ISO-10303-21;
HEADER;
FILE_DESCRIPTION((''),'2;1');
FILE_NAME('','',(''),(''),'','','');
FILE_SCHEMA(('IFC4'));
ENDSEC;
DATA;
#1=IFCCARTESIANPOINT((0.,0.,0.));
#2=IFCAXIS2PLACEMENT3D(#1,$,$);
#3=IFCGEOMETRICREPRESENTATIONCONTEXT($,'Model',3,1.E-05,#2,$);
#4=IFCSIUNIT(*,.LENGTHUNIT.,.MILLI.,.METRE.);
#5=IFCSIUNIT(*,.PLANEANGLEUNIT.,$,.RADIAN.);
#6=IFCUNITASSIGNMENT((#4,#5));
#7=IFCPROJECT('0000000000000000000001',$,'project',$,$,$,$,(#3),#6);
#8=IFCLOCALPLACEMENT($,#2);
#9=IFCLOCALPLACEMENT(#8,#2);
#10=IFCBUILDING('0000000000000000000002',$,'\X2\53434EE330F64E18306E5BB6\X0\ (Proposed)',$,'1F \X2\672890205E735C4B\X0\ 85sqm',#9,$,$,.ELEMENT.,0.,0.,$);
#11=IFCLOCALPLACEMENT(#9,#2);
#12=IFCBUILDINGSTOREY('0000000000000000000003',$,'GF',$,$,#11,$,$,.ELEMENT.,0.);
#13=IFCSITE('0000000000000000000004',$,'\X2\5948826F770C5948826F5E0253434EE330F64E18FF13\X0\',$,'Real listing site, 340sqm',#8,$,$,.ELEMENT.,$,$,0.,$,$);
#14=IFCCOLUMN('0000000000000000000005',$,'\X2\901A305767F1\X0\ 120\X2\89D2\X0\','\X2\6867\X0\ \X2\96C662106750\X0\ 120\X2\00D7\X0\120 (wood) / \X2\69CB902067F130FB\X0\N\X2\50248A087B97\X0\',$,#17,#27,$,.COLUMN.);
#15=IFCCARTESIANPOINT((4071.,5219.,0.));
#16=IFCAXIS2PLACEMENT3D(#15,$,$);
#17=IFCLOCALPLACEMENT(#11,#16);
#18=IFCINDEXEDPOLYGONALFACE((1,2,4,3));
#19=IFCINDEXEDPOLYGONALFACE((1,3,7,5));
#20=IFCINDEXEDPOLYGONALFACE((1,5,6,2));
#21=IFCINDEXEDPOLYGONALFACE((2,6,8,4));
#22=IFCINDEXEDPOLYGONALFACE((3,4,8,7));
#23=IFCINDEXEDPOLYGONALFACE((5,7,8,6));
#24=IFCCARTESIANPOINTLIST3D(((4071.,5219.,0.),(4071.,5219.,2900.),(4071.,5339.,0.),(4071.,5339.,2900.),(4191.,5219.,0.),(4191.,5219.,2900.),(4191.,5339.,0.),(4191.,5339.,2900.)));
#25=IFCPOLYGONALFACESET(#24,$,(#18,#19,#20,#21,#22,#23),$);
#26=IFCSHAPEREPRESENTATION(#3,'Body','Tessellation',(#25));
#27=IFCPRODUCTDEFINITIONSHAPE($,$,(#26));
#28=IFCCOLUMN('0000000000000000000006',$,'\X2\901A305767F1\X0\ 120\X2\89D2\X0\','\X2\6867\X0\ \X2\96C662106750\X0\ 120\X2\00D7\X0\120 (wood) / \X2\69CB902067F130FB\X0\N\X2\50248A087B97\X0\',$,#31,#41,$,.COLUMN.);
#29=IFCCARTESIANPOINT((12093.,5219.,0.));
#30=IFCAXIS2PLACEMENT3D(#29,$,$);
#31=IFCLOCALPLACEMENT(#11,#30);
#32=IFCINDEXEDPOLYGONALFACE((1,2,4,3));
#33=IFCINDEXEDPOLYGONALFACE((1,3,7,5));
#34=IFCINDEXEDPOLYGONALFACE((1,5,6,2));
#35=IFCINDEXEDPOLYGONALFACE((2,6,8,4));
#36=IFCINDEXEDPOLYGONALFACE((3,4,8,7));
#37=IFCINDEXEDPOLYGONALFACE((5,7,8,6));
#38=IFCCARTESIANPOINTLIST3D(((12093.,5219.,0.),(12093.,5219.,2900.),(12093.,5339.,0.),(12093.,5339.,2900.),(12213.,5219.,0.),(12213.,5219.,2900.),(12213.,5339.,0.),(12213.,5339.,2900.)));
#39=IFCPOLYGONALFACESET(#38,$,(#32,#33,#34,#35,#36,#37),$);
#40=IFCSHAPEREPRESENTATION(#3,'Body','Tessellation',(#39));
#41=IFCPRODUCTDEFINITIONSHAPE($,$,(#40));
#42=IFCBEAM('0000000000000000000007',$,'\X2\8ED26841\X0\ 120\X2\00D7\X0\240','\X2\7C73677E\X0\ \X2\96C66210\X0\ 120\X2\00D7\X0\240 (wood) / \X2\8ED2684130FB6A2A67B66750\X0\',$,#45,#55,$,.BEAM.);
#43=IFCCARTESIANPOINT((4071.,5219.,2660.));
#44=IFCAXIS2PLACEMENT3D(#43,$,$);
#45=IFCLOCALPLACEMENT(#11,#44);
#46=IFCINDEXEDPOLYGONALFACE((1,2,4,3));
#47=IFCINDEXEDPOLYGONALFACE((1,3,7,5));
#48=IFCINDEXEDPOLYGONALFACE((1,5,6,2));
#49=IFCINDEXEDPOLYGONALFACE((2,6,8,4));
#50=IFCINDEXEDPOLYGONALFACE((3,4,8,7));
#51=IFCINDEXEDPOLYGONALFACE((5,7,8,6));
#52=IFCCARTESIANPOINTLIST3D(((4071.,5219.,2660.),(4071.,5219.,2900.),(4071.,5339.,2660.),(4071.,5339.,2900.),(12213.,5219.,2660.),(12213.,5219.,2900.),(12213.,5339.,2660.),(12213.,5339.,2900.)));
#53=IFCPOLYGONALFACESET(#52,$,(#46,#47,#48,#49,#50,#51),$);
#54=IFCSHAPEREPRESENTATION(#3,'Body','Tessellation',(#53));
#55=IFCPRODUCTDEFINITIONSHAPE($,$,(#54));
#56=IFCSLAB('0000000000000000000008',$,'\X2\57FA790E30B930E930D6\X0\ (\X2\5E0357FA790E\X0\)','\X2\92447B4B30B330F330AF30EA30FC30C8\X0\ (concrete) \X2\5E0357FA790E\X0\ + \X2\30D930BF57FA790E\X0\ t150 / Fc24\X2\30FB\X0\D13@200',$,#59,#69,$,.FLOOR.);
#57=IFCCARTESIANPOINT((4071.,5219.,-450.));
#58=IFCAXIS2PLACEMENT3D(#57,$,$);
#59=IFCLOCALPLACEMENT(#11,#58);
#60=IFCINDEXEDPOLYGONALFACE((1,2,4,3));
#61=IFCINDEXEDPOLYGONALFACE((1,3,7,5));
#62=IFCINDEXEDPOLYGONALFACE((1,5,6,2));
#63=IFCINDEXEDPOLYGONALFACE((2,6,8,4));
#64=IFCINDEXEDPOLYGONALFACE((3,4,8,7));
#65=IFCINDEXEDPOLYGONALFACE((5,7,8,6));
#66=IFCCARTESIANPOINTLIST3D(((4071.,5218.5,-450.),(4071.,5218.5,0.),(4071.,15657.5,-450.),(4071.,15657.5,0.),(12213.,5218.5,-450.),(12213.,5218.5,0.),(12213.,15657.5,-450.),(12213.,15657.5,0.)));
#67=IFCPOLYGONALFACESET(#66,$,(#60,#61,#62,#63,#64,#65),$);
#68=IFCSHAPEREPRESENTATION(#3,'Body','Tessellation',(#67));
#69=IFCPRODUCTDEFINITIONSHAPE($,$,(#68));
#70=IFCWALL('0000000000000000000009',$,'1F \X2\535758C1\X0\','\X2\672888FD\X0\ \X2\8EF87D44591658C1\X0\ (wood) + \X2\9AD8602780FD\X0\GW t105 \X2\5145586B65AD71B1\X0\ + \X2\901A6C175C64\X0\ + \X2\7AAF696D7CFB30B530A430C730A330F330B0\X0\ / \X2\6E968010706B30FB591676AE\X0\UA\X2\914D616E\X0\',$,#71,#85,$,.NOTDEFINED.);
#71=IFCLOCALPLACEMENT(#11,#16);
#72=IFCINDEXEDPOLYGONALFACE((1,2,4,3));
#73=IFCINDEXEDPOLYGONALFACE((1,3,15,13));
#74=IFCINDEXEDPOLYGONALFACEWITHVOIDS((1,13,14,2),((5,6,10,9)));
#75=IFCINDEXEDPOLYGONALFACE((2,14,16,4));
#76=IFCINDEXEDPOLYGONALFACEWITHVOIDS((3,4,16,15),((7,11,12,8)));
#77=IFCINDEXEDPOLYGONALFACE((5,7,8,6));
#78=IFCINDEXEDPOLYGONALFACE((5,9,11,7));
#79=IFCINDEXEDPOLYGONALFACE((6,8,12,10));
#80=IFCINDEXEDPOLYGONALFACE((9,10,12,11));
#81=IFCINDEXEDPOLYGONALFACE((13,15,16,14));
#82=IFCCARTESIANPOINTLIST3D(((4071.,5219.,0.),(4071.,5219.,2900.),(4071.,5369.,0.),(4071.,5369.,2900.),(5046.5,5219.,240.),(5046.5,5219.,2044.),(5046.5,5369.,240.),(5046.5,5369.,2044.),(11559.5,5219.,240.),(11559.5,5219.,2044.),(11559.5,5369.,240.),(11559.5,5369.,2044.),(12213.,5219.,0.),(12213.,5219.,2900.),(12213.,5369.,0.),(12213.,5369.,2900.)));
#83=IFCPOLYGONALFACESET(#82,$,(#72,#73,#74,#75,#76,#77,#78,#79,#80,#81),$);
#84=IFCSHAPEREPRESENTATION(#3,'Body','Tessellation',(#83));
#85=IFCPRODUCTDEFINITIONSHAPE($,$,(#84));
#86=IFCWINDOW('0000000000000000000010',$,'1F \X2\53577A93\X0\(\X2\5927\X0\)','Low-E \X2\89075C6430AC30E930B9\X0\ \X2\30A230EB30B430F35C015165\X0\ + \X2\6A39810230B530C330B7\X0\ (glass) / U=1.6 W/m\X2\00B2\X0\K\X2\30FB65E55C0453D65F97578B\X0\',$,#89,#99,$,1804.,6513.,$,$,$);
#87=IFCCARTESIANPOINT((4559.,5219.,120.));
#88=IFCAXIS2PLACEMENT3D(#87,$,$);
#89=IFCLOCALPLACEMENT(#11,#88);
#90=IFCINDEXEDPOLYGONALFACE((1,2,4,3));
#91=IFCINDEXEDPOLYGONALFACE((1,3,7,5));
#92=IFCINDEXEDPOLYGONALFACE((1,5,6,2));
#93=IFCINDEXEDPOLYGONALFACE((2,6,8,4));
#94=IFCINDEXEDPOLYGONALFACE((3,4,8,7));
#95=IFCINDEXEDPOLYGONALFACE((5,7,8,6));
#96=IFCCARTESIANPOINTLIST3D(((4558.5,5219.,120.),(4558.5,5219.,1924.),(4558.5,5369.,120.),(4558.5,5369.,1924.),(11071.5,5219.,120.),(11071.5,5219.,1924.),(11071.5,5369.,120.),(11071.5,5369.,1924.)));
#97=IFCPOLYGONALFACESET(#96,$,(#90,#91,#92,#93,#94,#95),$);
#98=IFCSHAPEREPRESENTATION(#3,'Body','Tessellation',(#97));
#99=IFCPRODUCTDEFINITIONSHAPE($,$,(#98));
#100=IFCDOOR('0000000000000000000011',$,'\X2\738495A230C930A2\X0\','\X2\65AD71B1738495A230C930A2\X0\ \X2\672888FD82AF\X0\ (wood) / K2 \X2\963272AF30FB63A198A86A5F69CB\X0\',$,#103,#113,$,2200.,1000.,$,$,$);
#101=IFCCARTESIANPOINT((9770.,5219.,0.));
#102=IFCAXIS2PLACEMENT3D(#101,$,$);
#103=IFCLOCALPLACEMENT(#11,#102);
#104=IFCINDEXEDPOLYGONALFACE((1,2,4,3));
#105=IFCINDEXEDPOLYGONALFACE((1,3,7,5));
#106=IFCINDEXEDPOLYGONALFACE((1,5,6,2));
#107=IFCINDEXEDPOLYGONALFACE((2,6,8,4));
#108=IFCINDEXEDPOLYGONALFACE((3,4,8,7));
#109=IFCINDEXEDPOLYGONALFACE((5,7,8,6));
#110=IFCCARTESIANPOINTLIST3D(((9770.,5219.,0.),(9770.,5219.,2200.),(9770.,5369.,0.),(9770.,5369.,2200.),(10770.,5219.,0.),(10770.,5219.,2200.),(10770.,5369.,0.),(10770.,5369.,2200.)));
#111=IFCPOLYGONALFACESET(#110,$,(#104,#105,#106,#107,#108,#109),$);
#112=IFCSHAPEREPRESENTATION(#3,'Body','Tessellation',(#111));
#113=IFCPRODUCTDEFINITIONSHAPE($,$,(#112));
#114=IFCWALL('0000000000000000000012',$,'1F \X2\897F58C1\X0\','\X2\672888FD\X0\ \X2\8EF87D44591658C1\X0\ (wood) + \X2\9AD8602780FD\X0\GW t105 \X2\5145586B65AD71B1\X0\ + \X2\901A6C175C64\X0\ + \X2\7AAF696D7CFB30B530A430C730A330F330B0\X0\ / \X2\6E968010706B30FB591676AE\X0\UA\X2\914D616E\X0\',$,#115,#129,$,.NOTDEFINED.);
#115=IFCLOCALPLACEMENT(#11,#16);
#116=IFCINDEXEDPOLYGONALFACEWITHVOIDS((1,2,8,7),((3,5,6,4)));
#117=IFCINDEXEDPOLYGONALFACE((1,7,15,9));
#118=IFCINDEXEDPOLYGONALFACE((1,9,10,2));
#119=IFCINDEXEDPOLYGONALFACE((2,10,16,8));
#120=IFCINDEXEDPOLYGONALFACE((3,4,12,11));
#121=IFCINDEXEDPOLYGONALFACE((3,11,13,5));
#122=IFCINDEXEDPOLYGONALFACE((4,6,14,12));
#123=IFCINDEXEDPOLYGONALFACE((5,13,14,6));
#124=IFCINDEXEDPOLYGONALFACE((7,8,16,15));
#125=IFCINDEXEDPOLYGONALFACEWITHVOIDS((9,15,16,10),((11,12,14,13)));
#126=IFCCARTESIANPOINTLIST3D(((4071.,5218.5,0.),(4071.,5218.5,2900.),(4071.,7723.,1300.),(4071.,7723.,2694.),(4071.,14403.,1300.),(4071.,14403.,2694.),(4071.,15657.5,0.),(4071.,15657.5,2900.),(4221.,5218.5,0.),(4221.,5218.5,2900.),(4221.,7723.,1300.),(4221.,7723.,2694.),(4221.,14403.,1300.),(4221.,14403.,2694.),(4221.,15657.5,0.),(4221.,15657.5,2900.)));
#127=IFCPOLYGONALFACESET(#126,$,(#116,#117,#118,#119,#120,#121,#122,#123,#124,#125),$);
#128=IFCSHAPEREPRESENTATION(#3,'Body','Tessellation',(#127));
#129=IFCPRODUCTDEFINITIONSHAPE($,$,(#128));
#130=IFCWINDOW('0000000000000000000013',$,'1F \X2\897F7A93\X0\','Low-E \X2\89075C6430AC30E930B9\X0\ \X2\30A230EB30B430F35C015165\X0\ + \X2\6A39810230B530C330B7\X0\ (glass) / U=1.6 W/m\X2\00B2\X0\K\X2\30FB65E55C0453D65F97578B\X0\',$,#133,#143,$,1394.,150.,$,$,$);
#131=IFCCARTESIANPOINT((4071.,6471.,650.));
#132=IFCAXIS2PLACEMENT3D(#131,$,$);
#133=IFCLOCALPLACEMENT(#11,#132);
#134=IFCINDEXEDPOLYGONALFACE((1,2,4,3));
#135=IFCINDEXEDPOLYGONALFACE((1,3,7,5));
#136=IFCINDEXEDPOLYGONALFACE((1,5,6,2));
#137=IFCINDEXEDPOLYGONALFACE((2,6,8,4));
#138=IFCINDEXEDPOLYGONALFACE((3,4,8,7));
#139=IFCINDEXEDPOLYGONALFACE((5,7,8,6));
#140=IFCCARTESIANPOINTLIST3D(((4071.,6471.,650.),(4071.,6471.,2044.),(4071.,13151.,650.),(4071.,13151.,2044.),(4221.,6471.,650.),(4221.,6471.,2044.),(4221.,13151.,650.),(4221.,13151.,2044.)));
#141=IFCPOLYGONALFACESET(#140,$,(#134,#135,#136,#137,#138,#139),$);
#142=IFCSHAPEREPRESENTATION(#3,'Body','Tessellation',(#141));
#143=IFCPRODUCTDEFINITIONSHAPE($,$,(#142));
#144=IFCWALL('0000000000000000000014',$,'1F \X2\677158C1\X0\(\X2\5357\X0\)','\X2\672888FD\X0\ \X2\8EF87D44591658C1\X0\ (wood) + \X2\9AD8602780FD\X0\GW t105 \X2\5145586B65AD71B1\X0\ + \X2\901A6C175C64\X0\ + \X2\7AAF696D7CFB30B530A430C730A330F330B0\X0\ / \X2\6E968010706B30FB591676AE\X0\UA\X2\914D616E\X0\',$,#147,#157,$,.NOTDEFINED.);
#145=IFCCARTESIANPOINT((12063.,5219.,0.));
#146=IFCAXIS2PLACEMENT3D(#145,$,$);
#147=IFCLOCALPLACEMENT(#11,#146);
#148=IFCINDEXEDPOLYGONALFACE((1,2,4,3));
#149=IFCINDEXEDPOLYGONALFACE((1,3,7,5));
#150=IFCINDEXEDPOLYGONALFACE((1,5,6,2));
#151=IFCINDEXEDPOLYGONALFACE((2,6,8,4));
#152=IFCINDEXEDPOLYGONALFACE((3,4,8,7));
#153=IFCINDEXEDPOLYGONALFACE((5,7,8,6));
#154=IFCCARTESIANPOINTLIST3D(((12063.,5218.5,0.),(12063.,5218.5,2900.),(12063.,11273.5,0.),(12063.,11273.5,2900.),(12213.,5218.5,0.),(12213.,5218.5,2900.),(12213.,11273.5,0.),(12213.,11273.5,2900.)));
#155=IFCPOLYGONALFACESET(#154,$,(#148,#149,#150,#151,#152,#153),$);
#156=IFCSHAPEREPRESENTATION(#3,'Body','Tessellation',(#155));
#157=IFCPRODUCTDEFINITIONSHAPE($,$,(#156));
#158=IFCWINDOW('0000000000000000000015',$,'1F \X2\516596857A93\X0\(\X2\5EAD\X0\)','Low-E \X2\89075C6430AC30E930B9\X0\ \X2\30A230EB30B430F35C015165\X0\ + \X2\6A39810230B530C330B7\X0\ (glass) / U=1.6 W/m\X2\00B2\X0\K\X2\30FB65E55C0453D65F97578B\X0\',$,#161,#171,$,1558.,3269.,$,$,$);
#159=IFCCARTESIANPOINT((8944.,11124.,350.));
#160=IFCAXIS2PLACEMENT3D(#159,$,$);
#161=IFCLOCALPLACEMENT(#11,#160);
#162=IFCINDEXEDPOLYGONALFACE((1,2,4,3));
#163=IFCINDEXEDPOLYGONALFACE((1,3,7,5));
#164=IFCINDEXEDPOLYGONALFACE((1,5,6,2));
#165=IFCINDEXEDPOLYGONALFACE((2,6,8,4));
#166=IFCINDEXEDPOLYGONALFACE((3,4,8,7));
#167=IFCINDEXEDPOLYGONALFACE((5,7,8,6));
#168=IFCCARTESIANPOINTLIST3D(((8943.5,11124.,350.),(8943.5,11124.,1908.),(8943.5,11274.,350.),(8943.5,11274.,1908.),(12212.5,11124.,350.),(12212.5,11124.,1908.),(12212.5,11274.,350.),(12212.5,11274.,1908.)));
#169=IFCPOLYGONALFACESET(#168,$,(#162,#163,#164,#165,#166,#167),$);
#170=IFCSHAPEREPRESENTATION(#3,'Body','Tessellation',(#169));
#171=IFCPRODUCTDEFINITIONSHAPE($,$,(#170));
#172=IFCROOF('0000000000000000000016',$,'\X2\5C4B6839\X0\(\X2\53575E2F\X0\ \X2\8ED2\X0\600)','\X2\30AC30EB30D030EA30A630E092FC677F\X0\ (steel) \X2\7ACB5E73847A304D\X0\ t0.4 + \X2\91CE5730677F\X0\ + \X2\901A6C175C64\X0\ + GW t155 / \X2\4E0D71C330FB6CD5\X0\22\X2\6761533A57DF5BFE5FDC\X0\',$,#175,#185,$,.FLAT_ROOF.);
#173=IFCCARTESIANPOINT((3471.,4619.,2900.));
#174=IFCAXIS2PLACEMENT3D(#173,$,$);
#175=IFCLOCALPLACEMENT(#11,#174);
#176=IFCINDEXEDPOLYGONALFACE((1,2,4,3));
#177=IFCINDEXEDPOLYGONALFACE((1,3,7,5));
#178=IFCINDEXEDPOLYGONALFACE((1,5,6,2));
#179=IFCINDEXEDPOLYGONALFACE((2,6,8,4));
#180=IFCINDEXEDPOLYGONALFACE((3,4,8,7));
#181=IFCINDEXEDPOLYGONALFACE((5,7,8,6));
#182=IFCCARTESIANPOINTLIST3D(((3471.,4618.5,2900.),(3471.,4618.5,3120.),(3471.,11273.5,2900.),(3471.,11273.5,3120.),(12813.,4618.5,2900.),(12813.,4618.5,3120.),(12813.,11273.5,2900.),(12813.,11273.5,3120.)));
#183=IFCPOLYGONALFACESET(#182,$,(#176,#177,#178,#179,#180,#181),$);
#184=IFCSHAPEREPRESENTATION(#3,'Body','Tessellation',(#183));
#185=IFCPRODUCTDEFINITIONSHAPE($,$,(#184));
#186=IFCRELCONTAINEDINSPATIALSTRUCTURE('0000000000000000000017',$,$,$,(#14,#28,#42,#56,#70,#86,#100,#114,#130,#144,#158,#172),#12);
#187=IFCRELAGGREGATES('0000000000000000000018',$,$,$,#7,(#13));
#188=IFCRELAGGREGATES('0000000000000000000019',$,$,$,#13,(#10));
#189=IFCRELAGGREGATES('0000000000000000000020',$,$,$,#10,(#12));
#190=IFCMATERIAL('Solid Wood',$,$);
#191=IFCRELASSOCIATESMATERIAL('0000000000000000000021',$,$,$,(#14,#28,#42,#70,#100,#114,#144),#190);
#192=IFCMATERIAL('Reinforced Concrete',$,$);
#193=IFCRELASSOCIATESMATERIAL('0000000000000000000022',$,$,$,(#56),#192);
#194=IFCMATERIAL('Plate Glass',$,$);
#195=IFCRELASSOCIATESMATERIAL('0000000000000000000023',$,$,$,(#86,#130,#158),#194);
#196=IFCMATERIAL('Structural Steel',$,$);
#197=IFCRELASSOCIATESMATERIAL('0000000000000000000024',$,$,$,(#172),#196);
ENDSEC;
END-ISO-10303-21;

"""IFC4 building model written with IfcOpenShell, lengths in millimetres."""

from ifc_helpers import new_model, si_unit, frame, frame_2d, origin, place, context, project, spatial, rectangle, extrude, material, element, fill, save


model = new_model("IFC4")

# Units and contexts
model_context = context("Model", 3, precision=1e-05, world=origin())
ifc_project = project(units=[si_unit("LENGTHUNIT", "METRE", prefix="MILLI"), si_unit("PLANEANGLEUNIT", "RADIAN")], contexts=[model_context])

# Site, building, storey
site_placement = place(None, origin())
site = spatial("IfcSite", under=ifc_project, at=site_placement, Name="奈良県奈良市千代ヶ丘３", ObjectType="Real listing site, 340sqm", CompositionType="ELEMENT", RefElevation=0.0)
building_placement = place(site_placement, origin())
building = spatial("IfcBuilding", under=site, at=building_placement, Name="千代ヶ丘の家 (Proposed)", ObjectType="1F 木造平屋 85sqm", CompositionType="ELEMENT", ElevationOfRefHeight=0.0, ElevationOfTerrain=0.0)
storey_placement = place(building_placement, origin())
storey = spatial("IfcBuildingStorey", under=building, at=storey_placement, Name="GF", CompositionType="ELEMENT", Elevation=0.0)

# Columns
ifc_material_1 = material(Name="Solid Wood")
column_1_placement = place(storey_placement, frame((4071.0, 5219.0, 0.0)))
element("IfcColumn", 1, at=column_1_placement, inside=storey, material=ifc_material_1, Name="通し柱 120角", Description="桧 集成材 120×120 (wood) / 構造柱・N値計算", PredefinedType="COLUMN", context=model_context, shape_type="SweptSolid", body=[
    extrude(rectangle(XDim=120.0, YDim=120.0, at=frame_2d((60.0, 60.0))), frame((4071.0, 5219.0, 0.0)), (0.0, 0.0, 1.0), 2900.0),
])
column_2_placement = place(storey_placement, frame((12093.0, 5219.0, 0.0)))
element("IfcColumn", 2, at=column_2_placement, inside=storey, material=ifc_material_1, Name="通し柱 120角", Description="桧 集成材 120×120 (wood) / 構造柱・N値計算", PredefinedType="COLUMN", context=model_context, shape_type="SweptSolid", body=[
    extrude(rectangle(XDim=120.0, YDim=120.0, at=frame_2d((60.0, 60.0))), frame((12093.0, 5219.0, 0.0)), (0.0, 0.0, 1.0), 2900.0),
])

# Beam
beam_1_placement = place(storey_placement, frame((4071.0, 5219.0, 2660.0)))
element("IfcBeam", 3, at=beam_1_placement, inside=storey, material=ifc_material_1, Name="軒桁 120×240", Description="米松 集成 120×240 (wood) / 軒桁・横架材", PredefinedType="BEAM", context=model_context, shape_type="SweptSolid", body=[
    extrude(rectangle(XDim=8142.0, YDim=120.0, at=frame_2d((4071.0, 60.0))), frame((4071.0, 5219.0, 2660.0)), (0.0, 0.0, 1.0), 240.0),
])

# Slab
ifc_material_2 = material(Name="Reinforced Concrete")
slab_1_placement = place(storey_placement, frame((4071.0, 5219.0, -450.0)))
element("IfcSlab", 4, at=slab_1_placement, inside=storey, material=ifc_material_2, Name="基礎スラブ (布基礎)", Description="鉄筋コンクリート (concrete) 布基礎 + ベタ基礎 t150 / Fc24・D13@200", PredefinedType="FLOOR", context=model_context, shape_type="SweptSolid", body=[
    extrude(rectangle(XDim=8142.0, YDim=10439.0, at=frame_2d((4071.0, 5219.0))), frame((4071.0, 5219.0, -450.0)), (0.0, 0.0, 1.0), 450.0),
])

# Wall, openings, window, door
wall_1_placement = place(storey_placement, frame((4071.0, 5219.0, 0.0)))
wall_1 = element("IfcWall", 5, at=wall_1_placement, inside=storey, material=ifc_material_1, Name="1F 南壁", Description="木製 軸組外壁 (wood) + 高性能GW t105 充填断熱 + 通気層 + 窯業系サイディング / 準耐火・外皮UA配慮", PredefinedType="NOTDEFINED", context=model_context, shape_type="SweptSolid", body=[
    extrude(rectangle(XDim=8142.0, YDim=150.0, at=frame_2d((4071.0, 75.0))), frame((4071.0, 5219.0, 0.0)), (0.0, 0.0, 1.0), 2900.0),
])
opening_1_placement = place(storey_placement, frame((4559.0, 5219.0, 120.0)))
opening_1 = element("IfcOpeningElement", 6, at=opening_1_placement, cuts=wall_1, PredefinedType="NOTDEFINED", context=model_context, shape_type="SweptSolid", body=[
    extrude(rectangle(XDim=6513.0, YDim=150.0, at=frame_2d((3256.0, 75.0))), frame((4559.0, 5219.0, 120.0)), (0.0, 0.0, 1.0), 1804.0),
])
opening_2_placement = place(storey_placement, frame((9770.0, 5219.0, 0.0)))
opening_2 = element("IfcOpeningElement", 7, at=opening_2_placement, cuts=wall_1, PredefinedType="NOTDEFINED", context=model_context, shape_type="SweptSolid", body=[
    extrude(rectangle(XDim=1000.0, YDim=150.0, at=frame_2d((500.0, 75.0))), frame((9770.0, 5219.0, 0.0)), (0.0, 0.0, 1.0), 2200.0),
])
ifc_material_3 = material(Name="Plate Glass")
window_1_placement = place(storey_placement, frame((4559.0, 5219.0, 120.0)))
window_1 = element("IfcWindow", 8, at=window_1_placement, inside=storey, material=ifc_material_3, Name="1F 南窓(大)", Description="Low-E 複層ガラス アルゴン封入 + 樹脂サッシ (glass) / U=1.6 W/m²K・日射取得型", OverallHeight=1804.0, OverallWidth=6513.0, context=model_context, shape_type="SweptSolid", body=[
    extrude(rectangle(XDim=6513.0, YDim=150.0, at=frame_2d((3256.0, 75.0))), frame((4559.0, 5219.0, 120.0)), (0.0, 0.0, 1.0), 1804.0),
])
fill(opening_1, window_1)
door_1_placement = place(storey_placement, frame((9770.0, 5219.0, 0.0)))
door_1 = element("IfcDoor", 9, at=door_1_placement, inside=storey, material=ifc_material_1, Name="玄関ドア", Description="断熱玄関ドア 木製芯 (wood) / K2 防犯・採風機構", OverallHeight=2200.0, OverallWidth=1000.0, context=model_context, shape_type="SweptSolid", body=[
    extrude(rectangle(XDim=1000.0, YDim=150.0, at=frame_2d((500.0, 75.0))), frame((9770.0, 5219.0, 0.0)), (0.0, 0.0, 1.0), 2200.0),
])
fill(opening_2, door_1)

# Walls, openings, windows
wall_2_placement = place(storey_placement, frame((4071.0, 5219.0, 0.0)))
wall_2 = element("IfcWall", 10, at=wall_2_placement, inside=storey, material=ifc_material_1, Name="1F 西壁", Description="木製 軸組外壁 (wood) + 高性能GW t105 充填断熱 + 通気層 + 窯業系サイディング / 準耐火・外皮UA配慮", PredefinedType="NOTDEFINED", context=model_context, shape_type="SweptSolid", body=[
    extrude(rectangle(XDim=150.0, YDim=10439.0, at=frame_2d((75.0, 5219.0))), frame((4071.0, 5219.0, 0.0)), (0.0, 0.0, 1.0), 2900.0),
])
opening_3_placement = place(storey_placement, frame((4071.0, 6471.0, 650.0)))
opening_3 = element("IfcOpeningElement", 11, at=opening_3_placement, cuts=wall_2, PredefinedType="NOTDEFINED", context=model_context, shape_type="SweptSolid", body=[
    extrude(rectangle(XDim=150.0, YDim=6680.0, at=frame_2d((75.0, 3340.0))), frame((4071.0, 6471.0, 650.0)), (0.0, 0.0, 1.0), 1394.0),
])
window_2_placement = place(storey_placement, frame((4071.0, 6471.0, 650.0)))
window_2 = element("IfcWindow", 12, at=window_2_placement, inside=storey, material=ifc_material_3, Name="1F 西窓", Description="Low-E 複層ガラス アルゴン封入 + 樹脂サッシ (glass) / U=1.6 W/m²K・日射取得型", OverallHeight=1394.0, OverallWidth=150.0, context=model_context, shape_type="SweptSolid", body=[
    extrude(rectangle(XDim=150.0, YDim=6680.0, at=frame_2d((75.0, 3340.0))), frame((4071.0, 6471.0, 650.0)), (0.0, 0.0, 1.0), 1394.0),
])
fill(opening_3, window_2)
wall_3_placement = place(storey_placement, frame((12063.0, 5219.0, 0.0)))
wall_3 = element("IfcWall", 13, at=wall_3_placement, inside=storey, material=ifc_material_1, Name="1F 東壁(南)", Description="木製 軸組外壁 (wood) + 高性能GW t105 充填断熱 + 通気層 + 窯業系サイディング / 準耐火・外皮UA配慮", PredefinedType="NOTDEFINED", context=model_context, shape_type="SweptSolid", body=[
    extrude(rectangle(XDim=150.0, YDim=6055.0, at=frame_2d((75.0, 3027.0))), frame((12063.0, 5219.0, 0.0)), (0.0, 0.0, 1.0), 2900.0),
])
opening_4_placement = place(storey_placement, frame((8944.0, 11124.0, 350.0)))
opening_4 = element("IfcOpeningElement", 14, at=opening_4_placement, cuts=wall_3, PredefinedType="NOTDEFINED", context=model_context, shape_type="SweptSolid", body=[
    extrude(rectangle(XDim=3269.0, YDim=150.0, at=frame_2d((1634.0, 75.0))), frame((8944.0, 11124.0, 350.0)), (0.0, 0.0, 1.0), 1558.0),
])
window_3_placement = place(storey_placement, frame((8944.0, 11124.0, 350.0)))
window_3 = element("IfcWindow", 15, at=window_3_placement, inside=storey, material=ifc_material_3, Name="1F 入隅窓(庭)", Description="Low-E 複層ガラス アルゴン封入 + 樹脂サッシ (glass) / U=1.6 W/m²K・日射取得型", OverallHeight=1558.0, OverallWidth=3269.0, context=model_context, shape_type="SweptSolid", body=[
    extrude(rectangle(XDim=3269.0, YDim=150.0, at=frame_2d((1634.0, 75.0))), frame((8944.0, 11124.0, 350.0)), (0.0, 0.0, 1.0), 1558.0),
])
fill(opening_4, window_3)

# Roof
ifc_material_4 = material(Name="Structural Steel")
roof_placement = place(storey_placement, frame((3471.0, 4619.0, 2900.0)))
element("IfcRoof", 16, at=roof_placement, inside=storey, material=ifc_material_4, Name="屋根(南帯 軒600)", Description="ガルバリウム鋼板 (steel) 立平葺き t0.4 + 野地板 + 通気層 + GW t155 / 不燃・法22条区域対応", PredefinedType="FLAT_ROOF", context=model_context, shape_type="SweptSolid", body=[
    extrude(rectangle(XDim=9342.0, YDim=6655.0, at=frame_2d((4671.0, 3327.0))), frame((3471.0, 4619.0, 2900.0)), (0.0, 0.0, 1.0), 220.0),
])

save(model, "model.ifc")
